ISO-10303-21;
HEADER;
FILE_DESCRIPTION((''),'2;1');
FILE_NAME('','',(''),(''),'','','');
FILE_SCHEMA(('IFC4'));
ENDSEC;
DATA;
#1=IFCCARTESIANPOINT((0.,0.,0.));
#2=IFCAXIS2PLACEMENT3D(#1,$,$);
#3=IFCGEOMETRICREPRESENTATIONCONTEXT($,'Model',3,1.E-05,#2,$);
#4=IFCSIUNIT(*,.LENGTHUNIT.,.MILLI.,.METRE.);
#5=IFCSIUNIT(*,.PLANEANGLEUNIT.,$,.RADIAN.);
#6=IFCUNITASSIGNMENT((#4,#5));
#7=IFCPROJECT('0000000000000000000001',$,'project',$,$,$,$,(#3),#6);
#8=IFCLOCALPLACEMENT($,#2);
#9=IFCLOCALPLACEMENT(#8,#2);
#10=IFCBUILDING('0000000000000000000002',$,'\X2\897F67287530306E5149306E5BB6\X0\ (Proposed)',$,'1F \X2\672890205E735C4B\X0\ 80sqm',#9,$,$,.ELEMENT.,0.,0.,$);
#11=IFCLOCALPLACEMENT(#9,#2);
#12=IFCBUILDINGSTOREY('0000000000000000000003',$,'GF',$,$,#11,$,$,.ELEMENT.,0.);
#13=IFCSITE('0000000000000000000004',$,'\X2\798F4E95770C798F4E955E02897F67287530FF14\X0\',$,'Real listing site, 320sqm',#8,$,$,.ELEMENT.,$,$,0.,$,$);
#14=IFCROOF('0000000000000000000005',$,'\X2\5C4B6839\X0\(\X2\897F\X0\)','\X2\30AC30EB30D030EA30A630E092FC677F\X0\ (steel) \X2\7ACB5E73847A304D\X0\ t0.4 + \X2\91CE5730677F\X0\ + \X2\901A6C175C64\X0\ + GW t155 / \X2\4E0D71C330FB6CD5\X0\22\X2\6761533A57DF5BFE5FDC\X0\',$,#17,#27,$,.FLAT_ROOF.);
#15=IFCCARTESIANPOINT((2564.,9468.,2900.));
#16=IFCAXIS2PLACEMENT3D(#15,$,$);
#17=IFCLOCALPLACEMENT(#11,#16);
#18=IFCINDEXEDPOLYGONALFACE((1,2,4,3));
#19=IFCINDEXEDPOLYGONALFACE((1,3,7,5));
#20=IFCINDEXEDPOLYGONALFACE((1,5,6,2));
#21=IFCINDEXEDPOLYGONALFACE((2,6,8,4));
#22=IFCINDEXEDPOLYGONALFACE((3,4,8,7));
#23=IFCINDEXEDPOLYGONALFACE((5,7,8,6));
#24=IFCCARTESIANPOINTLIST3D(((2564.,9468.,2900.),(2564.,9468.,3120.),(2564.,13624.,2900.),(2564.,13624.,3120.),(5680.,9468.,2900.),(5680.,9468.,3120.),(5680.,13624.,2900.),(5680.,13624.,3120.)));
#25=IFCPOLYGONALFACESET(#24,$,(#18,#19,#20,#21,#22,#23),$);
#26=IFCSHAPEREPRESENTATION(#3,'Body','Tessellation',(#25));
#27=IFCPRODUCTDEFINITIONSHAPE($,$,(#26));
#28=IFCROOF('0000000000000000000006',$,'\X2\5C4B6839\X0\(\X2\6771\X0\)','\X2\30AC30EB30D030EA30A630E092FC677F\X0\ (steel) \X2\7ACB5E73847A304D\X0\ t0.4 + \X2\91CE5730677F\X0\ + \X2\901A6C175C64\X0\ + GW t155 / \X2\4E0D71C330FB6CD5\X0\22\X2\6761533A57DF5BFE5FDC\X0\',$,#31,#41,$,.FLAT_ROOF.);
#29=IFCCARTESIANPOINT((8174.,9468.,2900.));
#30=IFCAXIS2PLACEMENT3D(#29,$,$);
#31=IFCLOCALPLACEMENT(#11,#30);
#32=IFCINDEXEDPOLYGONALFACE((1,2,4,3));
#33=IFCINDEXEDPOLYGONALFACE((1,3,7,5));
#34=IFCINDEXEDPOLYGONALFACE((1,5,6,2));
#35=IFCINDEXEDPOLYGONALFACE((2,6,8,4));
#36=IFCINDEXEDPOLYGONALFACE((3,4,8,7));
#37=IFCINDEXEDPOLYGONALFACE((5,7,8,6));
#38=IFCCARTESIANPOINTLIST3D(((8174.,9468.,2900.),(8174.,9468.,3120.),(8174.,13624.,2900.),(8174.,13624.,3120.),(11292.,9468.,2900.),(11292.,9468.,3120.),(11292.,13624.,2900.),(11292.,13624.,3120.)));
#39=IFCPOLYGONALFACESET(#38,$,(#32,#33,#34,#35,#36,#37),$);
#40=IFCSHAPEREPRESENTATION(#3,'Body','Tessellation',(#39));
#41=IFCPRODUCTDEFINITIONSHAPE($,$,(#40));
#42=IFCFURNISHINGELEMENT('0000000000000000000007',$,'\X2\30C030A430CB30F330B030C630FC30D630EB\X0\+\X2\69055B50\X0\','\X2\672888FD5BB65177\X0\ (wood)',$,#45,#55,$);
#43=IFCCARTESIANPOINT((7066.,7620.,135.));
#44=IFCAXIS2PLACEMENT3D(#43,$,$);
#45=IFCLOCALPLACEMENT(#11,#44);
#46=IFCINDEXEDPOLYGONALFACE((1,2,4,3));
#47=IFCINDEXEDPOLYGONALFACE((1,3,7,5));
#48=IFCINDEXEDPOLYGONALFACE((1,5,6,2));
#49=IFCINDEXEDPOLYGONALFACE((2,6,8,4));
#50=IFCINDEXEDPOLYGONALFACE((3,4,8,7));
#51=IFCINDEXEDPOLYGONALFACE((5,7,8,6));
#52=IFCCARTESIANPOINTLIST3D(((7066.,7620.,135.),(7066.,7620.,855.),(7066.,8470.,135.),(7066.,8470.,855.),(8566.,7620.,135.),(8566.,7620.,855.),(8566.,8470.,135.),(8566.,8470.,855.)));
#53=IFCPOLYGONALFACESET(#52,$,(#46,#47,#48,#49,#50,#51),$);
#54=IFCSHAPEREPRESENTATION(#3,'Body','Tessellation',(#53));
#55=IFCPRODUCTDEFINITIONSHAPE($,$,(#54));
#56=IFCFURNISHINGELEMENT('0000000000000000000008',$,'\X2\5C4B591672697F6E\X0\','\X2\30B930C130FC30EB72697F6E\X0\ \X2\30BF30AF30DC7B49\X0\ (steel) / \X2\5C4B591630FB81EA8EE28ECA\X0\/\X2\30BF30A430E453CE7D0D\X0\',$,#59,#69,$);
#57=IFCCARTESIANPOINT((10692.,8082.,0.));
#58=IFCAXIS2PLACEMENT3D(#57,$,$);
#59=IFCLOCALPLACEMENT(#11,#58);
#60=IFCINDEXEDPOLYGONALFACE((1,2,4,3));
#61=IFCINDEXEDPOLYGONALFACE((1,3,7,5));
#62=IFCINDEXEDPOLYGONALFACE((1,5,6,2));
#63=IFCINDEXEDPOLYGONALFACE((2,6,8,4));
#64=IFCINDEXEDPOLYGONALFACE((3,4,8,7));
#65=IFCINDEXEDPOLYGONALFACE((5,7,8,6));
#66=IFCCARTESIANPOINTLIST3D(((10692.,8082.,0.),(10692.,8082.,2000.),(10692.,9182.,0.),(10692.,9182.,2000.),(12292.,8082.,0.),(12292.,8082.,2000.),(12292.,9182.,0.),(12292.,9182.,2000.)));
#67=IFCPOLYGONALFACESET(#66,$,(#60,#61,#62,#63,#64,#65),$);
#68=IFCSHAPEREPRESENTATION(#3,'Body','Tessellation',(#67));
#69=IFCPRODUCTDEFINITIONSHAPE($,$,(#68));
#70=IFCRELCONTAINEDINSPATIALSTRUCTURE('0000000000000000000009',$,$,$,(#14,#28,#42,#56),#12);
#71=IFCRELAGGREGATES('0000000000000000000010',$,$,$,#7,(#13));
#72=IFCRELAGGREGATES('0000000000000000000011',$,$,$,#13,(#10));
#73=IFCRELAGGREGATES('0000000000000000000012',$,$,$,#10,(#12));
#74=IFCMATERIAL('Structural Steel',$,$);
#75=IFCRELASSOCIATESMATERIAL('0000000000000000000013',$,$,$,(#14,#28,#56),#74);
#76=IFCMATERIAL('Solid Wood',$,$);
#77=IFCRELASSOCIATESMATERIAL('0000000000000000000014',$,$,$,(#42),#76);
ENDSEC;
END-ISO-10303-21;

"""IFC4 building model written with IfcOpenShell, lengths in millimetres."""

from ifc_helpers import new_model, si_unit, frame, frame_2d, origin, place, context, project, spatial, rectangle, extrude, material, element, save


model = new_model("IFC4")

# Units and contexts
model_context = context("Model", 3, precision=1e-05, world=origin())
ifc_project = project(units=[si_unit("LENGTHUNIT", "METRE", prefix="MILLI"), si_unit("PLANEANGLEUNIT", "RADIAN")], contexts=[model_context])

# Site, building, storey
site_placement = place(None, origin())
site = spatial("IfcSite", under=ifc_project, at=site_placement, Name="福井県福井市西木田４", ObjectType="Real listing site, 320sqm", CompositionType="ELEMENT", RefElevation=0.0)
building_placement = place(site_placement, origin())
building = spatial("IfcBuilding", under=site, at=building_placement, Name="西木田の光の家 (Proposed)", ObjectType="1F 木造平屋 80sqm", CompositionType="ELEMENT", ElevationOfRefHeight=0.0, ElevationOfTerrain=0.0)
storey_placement = place(building_placement, origin())
storey = spatial("IfcBuildingStorey", under=building, at=storey_placement, Name="GF", CompositionType="ELEMENT", Elevation=0.0)

# Shared definitions
ifc_material_1 = material(Name="Solid Wood")

# Roofs
ifc_material_2 = material(Name="Structural Steel")
roof_1_placement = place(storey_placement, frame((2564.0, 9468.0, 2900.0)))
element("IfcRoof", 1, at=roof_1_placement, inside=storey, material=ifc_material_2, Name="屋根(西)", Description="ガルバリウム鋼板 (steel) 立平葺き t0.4 + 野地板 + 通気層 + GW t155 / 不燃・法22条区域対応", PredefinedType="FLAT_ROOF", context=model_context, shape_type="SweptSolid", body=[
    extrude(rectangle(XDim=3116.0, YDim=4156.0, at=frame_2d((1558.0, 2078.0))), frame((2564.0, 9468.0, 2900.0)), (0.0, 0.0, 1.0), 220.0),
])
roof_2_placement = place(storey_placement, frame((8174.0, 9468.0, 2900.0)))
element("IfcRoof", 2, at=roof_2_placement, inside=storey, material=ifc_material_2, Name="屋根(東)", Description="ガルバリウム鋼板 (steel) 立平葺き t0.4 + 野地板 + 通気層 + GW t155 / 不燃・法22条区域対応", PredefinedType="FLAT_ROOF", context=model_context, shape_type="SweptSolid", body=[
    extrude(rectangle(XDim=3118.0, YDim=4156.0, at=frame_2d((1559.0, 2078.0))), frame((8174.0, 9468.0, 2900.0)), (0.0, 0.0, 1.0), 220.0),
])

# Furnishing elements
furnishing_1_placement = place(storey_placement, frame((7066.0, 7620.0, 135.0)))
element("IfcFurnishingElement", 3, at=furnishing_1_placement, inside=storey, material=ifc_material_1, Name="ダイニングテーブル+椅子", Description="木製家具 (wood)", context=model_context, shape_type="SweptSolid", body=[
    extrude(rectangle(XDim=1500.0, YDim=850.0, at=frame_2d((750.0, 425.0))), frame((7066.0, 7620.0, 135.0)), (0.0, 0.0, 1.0), 720.0),
])
furnishing_2_placement = place(storey_placement, frame((10692.0, 8082.0, 0.0)))
element("IfcFurnishingElement", 4, at=furnishing_2_placement, inside=storey, material=ifc_material_2, Name="屋外物置", Description="スチール物置 タクボ等 (steel) / 屋外・自転車/タイヤ収納", context=model_context, shape_type="SweptSolid", body=[
    extrude(rectangle(XDim=1600.0, YDim=1100.0, at=frame_2d((800.0, 550.0))), frame((10692.0, 8082.0, 0.0)), (0.0, 0.0, 1.0), 2000.0),
])

save(model, "model.ifc")
